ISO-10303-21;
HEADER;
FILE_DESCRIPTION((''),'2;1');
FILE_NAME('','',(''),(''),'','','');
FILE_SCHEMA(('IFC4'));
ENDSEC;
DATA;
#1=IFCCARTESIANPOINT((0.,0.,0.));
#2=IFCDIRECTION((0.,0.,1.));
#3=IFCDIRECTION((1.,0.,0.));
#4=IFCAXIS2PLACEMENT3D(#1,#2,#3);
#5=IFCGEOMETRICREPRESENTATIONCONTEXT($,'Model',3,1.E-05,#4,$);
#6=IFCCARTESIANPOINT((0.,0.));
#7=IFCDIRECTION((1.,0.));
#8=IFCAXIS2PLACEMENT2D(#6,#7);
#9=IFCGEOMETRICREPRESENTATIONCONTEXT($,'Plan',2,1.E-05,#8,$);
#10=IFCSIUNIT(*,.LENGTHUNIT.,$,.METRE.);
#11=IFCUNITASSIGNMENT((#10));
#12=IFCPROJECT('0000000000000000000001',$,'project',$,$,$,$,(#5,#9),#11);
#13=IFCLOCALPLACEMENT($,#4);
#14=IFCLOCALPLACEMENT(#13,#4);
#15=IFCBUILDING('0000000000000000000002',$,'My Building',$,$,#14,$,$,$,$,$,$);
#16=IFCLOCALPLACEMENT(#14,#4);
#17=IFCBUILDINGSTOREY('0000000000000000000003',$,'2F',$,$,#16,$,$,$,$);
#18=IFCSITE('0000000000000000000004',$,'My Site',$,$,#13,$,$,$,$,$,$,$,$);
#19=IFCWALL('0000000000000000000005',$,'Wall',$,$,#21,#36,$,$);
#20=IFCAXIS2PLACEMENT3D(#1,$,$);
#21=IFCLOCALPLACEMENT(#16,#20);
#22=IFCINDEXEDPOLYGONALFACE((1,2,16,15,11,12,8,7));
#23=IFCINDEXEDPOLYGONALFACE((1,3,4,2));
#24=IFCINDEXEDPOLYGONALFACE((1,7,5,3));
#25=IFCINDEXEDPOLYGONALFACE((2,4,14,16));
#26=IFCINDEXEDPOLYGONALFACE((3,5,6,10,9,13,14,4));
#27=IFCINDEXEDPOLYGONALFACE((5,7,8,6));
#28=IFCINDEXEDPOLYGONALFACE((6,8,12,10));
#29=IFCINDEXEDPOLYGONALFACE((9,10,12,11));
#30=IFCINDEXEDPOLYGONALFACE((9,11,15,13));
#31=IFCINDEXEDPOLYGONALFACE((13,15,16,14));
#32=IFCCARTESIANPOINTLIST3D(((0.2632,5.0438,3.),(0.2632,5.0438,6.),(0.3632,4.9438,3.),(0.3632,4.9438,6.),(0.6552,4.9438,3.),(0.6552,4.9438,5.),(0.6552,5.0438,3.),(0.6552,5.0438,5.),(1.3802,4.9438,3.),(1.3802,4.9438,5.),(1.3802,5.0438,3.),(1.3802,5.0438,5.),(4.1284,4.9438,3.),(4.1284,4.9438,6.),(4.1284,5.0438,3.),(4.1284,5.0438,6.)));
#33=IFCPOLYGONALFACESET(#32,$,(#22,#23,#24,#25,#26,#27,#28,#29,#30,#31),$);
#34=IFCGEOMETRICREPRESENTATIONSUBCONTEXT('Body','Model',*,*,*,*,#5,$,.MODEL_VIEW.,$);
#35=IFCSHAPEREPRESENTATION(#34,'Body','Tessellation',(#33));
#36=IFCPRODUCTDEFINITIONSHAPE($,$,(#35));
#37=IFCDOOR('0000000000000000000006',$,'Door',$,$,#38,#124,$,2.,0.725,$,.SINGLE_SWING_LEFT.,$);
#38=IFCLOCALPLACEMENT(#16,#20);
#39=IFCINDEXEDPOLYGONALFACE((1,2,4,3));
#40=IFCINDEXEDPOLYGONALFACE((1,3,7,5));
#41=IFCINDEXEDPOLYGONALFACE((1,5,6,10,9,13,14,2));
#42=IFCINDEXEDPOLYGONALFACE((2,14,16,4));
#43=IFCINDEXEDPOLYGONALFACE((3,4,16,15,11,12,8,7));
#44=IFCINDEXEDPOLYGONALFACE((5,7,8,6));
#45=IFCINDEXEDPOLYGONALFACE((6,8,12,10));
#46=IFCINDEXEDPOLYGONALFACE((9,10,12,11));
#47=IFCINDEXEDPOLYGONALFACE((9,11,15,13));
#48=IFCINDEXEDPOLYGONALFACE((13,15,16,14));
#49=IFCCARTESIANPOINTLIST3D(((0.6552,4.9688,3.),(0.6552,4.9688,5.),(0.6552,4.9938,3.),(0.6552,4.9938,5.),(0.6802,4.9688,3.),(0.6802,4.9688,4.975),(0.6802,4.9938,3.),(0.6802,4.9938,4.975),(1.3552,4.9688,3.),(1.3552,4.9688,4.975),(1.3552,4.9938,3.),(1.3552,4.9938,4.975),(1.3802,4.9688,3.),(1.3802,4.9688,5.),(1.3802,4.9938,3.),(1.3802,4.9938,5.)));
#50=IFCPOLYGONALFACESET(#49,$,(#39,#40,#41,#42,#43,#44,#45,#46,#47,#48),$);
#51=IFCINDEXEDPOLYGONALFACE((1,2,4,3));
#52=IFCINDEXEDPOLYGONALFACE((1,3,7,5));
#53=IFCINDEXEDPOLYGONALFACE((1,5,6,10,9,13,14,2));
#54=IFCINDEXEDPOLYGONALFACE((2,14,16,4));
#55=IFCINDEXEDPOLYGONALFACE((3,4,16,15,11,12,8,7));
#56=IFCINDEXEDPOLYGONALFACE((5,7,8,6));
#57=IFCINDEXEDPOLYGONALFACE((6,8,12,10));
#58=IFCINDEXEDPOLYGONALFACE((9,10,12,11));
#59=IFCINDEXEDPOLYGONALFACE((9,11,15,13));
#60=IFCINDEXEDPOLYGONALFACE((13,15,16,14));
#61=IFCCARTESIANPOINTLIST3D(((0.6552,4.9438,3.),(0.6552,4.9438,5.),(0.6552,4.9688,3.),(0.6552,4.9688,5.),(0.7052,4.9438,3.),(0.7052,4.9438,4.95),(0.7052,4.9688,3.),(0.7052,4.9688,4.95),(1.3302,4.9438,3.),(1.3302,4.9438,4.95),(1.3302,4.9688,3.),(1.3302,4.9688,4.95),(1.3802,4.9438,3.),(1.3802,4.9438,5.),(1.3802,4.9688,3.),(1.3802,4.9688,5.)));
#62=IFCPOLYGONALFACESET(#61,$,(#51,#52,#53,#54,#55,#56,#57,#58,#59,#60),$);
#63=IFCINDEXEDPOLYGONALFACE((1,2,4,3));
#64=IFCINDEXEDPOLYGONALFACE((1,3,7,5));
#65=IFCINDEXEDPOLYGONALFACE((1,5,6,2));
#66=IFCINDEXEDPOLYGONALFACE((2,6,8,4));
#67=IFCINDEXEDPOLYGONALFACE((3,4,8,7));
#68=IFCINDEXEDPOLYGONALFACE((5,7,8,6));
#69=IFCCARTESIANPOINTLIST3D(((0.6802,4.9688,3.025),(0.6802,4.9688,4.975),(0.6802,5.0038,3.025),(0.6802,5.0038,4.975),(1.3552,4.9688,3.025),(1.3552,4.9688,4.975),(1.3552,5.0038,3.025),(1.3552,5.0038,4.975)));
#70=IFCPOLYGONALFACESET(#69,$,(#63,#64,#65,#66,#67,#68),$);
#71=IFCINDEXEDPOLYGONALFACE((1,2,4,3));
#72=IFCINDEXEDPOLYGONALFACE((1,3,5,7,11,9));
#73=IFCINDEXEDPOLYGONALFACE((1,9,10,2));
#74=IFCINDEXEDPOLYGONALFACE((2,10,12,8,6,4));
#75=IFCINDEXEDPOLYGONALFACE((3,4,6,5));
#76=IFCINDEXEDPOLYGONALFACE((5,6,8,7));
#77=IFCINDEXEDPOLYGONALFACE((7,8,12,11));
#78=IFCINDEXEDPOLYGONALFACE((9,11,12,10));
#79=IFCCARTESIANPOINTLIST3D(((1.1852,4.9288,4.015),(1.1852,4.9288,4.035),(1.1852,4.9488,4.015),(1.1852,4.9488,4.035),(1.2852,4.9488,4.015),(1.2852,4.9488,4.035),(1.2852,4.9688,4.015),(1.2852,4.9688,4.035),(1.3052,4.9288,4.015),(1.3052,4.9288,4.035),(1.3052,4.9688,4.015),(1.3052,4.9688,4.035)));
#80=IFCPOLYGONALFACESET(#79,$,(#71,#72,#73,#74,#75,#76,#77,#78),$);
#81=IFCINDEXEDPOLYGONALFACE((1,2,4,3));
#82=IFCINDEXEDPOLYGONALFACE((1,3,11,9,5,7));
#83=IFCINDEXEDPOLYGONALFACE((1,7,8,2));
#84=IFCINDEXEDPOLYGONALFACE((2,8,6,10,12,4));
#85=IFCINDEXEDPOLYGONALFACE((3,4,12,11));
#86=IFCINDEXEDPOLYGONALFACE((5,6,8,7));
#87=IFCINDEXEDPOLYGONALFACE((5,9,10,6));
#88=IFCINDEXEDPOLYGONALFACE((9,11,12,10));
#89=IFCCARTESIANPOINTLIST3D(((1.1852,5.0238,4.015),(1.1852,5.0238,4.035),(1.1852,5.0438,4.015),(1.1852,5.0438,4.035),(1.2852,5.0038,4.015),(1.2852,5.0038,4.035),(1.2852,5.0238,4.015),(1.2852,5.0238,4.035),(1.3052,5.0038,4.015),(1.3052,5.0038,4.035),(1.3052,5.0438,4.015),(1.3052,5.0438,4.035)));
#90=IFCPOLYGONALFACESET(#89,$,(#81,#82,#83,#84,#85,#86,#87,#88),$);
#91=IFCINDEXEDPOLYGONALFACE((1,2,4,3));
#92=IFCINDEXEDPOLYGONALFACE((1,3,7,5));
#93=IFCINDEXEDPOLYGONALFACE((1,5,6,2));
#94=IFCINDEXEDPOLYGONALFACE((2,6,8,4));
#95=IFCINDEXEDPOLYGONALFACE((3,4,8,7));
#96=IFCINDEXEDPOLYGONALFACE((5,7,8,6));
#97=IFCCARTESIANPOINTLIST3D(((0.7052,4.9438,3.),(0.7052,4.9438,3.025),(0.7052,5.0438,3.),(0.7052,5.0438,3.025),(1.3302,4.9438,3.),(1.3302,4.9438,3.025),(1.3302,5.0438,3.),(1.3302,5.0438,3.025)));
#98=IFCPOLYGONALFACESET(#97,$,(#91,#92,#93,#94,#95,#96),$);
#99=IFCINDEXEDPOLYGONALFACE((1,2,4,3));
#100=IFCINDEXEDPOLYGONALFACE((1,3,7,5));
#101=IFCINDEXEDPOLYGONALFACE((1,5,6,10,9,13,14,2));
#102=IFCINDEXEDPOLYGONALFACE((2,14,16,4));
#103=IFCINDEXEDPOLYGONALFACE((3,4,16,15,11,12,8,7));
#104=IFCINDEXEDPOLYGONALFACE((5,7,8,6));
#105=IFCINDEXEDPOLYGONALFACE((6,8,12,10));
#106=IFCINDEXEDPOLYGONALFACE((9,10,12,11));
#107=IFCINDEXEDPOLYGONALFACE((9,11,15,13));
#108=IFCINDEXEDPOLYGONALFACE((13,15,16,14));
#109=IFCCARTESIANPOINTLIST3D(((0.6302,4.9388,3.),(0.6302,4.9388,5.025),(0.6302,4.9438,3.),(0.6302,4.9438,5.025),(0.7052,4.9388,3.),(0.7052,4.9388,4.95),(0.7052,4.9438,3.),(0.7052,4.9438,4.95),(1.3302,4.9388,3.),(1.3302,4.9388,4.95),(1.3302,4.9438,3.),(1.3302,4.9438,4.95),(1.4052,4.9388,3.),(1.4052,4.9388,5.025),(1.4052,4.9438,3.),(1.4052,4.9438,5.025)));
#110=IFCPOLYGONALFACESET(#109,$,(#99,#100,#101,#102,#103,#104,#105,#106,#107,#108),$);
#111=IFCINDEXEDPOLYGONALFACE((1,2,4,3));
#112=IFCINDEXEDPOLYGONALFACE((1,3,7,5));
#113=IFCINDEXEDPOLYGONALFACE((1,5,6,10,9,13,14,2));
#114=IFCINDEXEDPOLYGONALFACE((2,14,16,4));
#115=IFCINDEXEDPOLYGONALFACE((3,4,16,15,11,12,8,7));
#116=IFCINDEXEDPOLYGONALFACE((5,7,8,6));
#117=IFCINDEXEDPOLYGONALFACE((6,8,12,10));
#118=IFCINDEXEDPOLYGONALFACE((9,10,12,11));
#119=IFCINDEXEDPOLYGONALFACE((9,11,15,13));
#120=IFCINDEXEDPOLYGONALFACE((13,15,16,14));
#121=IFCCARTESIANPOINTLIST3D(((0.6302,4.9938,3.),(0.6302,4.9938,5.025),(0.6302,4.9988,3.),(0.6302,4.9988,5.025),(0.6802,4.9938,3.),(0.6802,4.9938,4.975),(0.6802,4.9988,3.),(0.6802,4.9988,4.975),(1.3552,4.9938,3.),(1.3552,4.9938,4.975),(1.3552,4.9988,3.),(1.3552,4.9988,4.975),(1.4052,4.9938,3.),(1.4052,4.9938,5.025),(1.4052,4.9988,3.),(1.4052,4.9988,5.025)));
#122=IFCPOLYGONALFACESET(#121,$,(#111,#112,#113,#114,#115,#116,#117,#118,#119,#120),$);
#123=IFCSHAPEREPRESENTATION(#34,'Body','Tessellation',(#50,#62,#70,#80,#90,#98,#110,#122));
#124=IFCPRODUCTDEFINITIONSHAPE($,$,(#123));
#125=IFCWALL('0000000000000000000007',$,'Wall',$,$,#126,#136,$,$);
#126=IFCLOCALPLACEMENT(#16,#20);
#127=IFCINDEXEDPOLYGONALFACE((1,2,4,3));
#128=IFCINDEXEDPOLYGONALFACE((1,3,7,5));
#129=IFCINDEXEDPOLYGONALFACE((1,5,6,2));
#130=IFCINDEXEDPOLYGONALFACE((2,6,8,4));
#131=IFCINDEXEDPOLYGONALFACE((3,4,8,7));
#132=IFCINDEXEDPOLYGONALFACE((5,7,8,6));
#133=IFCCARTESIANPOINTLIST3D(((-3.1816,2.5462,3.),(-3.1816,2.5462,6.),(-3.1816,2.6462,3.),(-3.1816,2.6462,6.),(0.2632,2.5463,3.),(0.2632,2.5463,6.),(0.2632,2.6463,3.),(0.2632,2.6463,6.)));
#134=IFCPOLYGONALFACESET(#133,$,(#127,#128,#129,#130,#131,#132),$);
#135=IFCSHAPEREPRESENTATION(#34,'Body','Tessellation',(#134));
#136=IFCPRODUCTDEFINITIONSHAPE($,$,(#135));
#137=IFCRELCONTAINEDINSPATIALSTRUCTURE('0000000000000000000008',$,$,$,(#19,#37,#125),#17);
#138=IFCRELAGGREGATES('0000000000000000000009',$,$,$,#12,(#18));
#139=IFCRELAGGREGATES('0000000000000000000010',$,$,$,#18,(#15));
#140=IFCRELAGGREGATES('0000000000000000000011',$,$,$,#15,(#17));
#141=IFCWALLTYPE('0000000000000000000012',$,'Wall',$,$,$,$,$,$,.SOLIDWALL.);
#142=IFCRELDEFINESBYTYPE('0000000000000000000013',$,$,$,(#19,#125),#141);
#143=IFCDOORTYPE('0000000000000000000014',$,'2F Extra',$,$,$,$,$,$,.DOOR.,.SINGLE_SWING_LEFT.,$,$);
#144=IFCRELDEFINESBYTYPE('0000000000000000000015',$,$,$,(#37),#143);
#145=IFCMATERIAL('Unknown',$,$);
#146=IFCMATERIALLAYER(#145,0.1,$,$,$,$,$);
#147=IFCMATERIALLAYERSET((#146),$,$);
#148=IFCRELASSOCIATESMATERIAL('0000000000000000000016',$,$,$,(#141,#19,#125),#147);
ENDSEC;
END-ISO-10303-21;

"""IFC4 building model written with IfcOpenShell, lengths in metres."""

from ifc_helpers import new_model, entity, si_unit, frame, origin_with_axes, origin_2d_with_axis, place, context, subcontext, project, spatial, line, indexed_curve, outline, extrude, shape, source, transform, mapped, material, layer, layer_set, layer_usage, type_object, type_shapes, element, fill, save


model = new_model("IFC4")

# Units and contexts
model_context = context("Model", 3, precision=1e-05, world=origin_with_axes())
plan_context = context("Plan", 2, precision=1e-05, world=origin_2d_with_axis())
body_context_1 = subcontext(model_context, "Body", "Model", "MODEL_VIEW")
body_context_2 = subcontext(plan_context, "Body", "Plan", "PLAN_VIEW")
ifc_project = project(units=[si_unit("LENGTHUNIT", "METRE")], contexts=[model_context, plan_context])

# Site, building, storey
site_placement = place(None, origin_with_axes())
site = spatial("IfcSite", under=ifc_project, at=site_placement, Name="My Site")
building_placement = place(site_placement, origin_with_axes())
building = spatial("IfcBuilding", under=site, at=building_placement, Name="My Building")
storey_placement = place(building_placement, origin_with_axes())
storey = spatial("IfcBuildingStorey", under=building, at=storey_placement, Name="2F")

# Shared definitions
ifc_material = material(Name="Unknown")
ifc_layer = layer(ifc_material, 0.1)
ifc_layer_set = layer_set([ifc_layer])
wall_type = type_object("IfcWallType", Name="Wall", PredefinedType="SOLIDWALL", material=ifc_layer_set)

# Wall, opening, door
ifc_layer_usage_1 = layer_usage(ifc_layer_set, "AXIS2", "POSITIVE", 0.0)
wall_1_placement = place(storey_placement, frame((4.1284, 5.0438, 3.0), z_axis=(0.0, 0.0, 1.0), x_axis=(-1.0, 0.0, 0.0)))
wall_1 = element("IfcWall", 1, at=wall_1_placement, inside=storey, type_object=wall_type, material=ifc_layer_usage_1, Name="Wall", context=body_context_1, shape_type="SweptSolid", body=[
    extrude(outline(indexed_curve([(0.0, 0.0), (0.0, 0.1), (3.7652, 0.1), (3.8652, 0.0)], segments=[line(1, 2, 3, 4, 1)])), origin_with_axes(), (0.0, 0.0, 1.0), 3.0),
])
shared_shape_1 = source(origin_with_axes(), body_context_1, "Body", "SweptSolid", [
    extrude(outline(indexed_curve([(0.0, 0.0), (0.725, 0.0), (0.725, 2.0), (0.0, 2.0)], segments=[line(1, 2, 3, 4, 1)])), frame((0.0, -0.6, 0.0), z_axis=(0.0, -1.0, 0.0), x_axis=(1.0, 0.0, 0.0)), (0.0, 0.0, -1.0), 1.2),
])
opening_1_placement = place(wall_1_placement, frame((3.4732, 0.1, 0.0), z_axis=(0.0, 0.0, 1.0), x_axis=(-1.0, 0.0, 0.0)))
opening_1 = element("IfcOpeningElement", 2, at=opening_1_placement, cuts=wall_1, PredefinedType="OPENING", context=body_context_1, shape_type="MappedRepresentation", body=[
    mapped(shared_shape_1, transform((0.0, 0.0, 0.0), x_axis=(1.0, 0.0, 0.0), y_axis=(0.0, 1.0, 0.0), z_axis=(0.0, 0.0, 1.0), scale=1.0)),
])
door_type_1 = type_object("IfcDoorType", Name="2F Extra", OperationType="SINGLE_SWING_LEFT", PredefinedType="DOOR")
shared_shape_2 = source(origin_with_axes(), body_context_1, "Body", "SweptSolid", [
    extrude(outline(indexed_curve([(0.0, 0.0), (0.0, 2.0), (0.725, 2.0), (0.725, 0.0), (0.7, 0.0), (0.7, 1.975), (0.025, 1.975), (0.025, 0.0)], segments=[line(1, 2, 3, 4, 5, 6, 7, 8, 1)])), frame((0.0, 0.025, 0.0), z_axis=(0.0, -1.0, 0.0), x_axis=(1.0, 0.0, 0.0)), (0.0, 0.0, -1.0), 0.025),
    extrude(outline(indexed_curve([(0.0, 0.0), (0.0, 2.0), (0.725, 2.0), (0.725, 0.0), (0.675, 0.0), (0.675, 1.95), (0.05, 1.95), (0.05, 0.0)], segments=[line(1, 2, 3, 4, 5, 6, 7, 8, 1)])), frame((0.0, 0.0, 0.0), z_axis=(0.0, -1.0, 0.0), x_axis=(1.0, 0.0, 0.0)), (0.0, 0.0, -1.0), 0.025),
    extrude(outline(indexed_curve([(0.0, 0.0), (0.675, 0.0), (0.675, 0.035), (0.0, 0.035)], segments=[line(1, 2, 3, 4, 1)])), frame((0.025, 0.025, 0.025), z_axis=(0.0, 0.0, 1.0), x_axis=(1.0, 0.0, 0.0)), (0.0, 0.0, 1.0), 1.95),
    extrude(outline(indexed_curve([(0.0, 0.0), (0.0, -0.04), (-0.12, -0.04), (-0.12, -0.02), (-0.02, -0.02), (-0.02, 0.0)], segments=[line(1, 2, 3, 4, 5, 6, 1)])), frame((0.65, 0.025, 1.015), z_axis=(0.0, 0.0, 1.0), x_axis=(1.0, 0.0, 0.0)), (0.0, 0.0, 1.0), 0.02),
    extrude(outline(indexed_curve([(0.0, 0.0), (0.0, 0.04), (-0.12, 0.04), (-0.12, 0.02), (-0.02, 0.02), (-0.02, 0.0)], segments=[line(1, 2, 3, 4, 5, 6, 1)])), frame((0.65, 0.06, 1.015), z_axis=(0.0, 0.0, 1.0), x_axis=(1.0, 0.0, 0.0)), (0.0, 0.0, 1.0), 0.02),
    extrude(outline(indexed_curve([(0.0, 0.0), (0.625, 0.0), (0.625, 0.1), (0.0, 0.1)], segments=[line(1, 2, 3, 4, 1)])), frame((0.05, 0.0, 0.0), z_axis=(0.0, 0.0, 1.0), x_axis=(1.0, 0.0, 0.0)), (0.0, 0.0, 1.0), 0.025),
    extrude(outline(indexed_curve([(0.0, 0.0), (0.0, 2.025), (0.775, 2.025), (0.775, 0.0), (0.7, 0.0), (0.7, 1.95), (0.075, 1.95), (0.075, 0.0)], segments=[line(1, 2, 3, 4, 5, 6, 7, 8, 1)])), frame((-0.025, -0.005, 0.0), z_axis=(0.0, -1.0, 0.0), x_axis=(1.0, 0.0, 0.0)), (0.0, 0.0, -1.0), 0.005),
    extrude(outline(indexed_curve([(0.0, 0.0), (0.0, 2.025), (0.775, 2.025), (0.775, 0.0), (0.725, 0.0), (0.725, 1.975), (0.05, 1.975), (0.05, 0.0)], segments=[line(1, 2, 3, 4, 5, 6, 7, 8, 1)])), frame((-0.025, 0.05, 0.0), z_axis=(0.0, -1.0, 0.0), x_axis=(1.0, 0.0, 0.0)), (0.0, 0.0, -1.0), 0.005),
])
shared_shape_3 = source(origin_with_axes(), body_context_2, "Body", "Curve2D", [
    entity("IfcIndexedPolyCurve", entity("IfcCartesianPointList2D", [[0.0, 0.0], [0.0, 0.05], [0.025, 0.05], [0.025, 0.025], [0.05, 0.025], [0.05, 0.0]]), [entity("IfcLineIndex", [1, 2, 3, 4, 5, 6, 1])]),
    entity("IfcIndexedPolyCurve", entity("IfcCartesianPointList2D", [[0.725, 0.0], [0.725, 0.05], [0.7, 0.05], [0.7, 0.025], [0.675, 0.025], [0.675, 0.0]]), [entity("IfcLineIndex", [1, 2, 3, 4, 5, 6, 1])]),
    entity("IfcTrimmedCurve", entity("IfcEllipse", entity("IfcAxis2Placement2D", entity("IfcCartesianPoint", [0.06, 0.05]), entity("IfcDirection", [1.0, 0.0])), 0.64, 0.675), [entity("IfcCartesianPoint", [0.7, 0.05])], [entity("IfcCartesianPoint", [0.06, 0.725])], True, "CARTESIAN"),
    entity("IfcIndexedPolyCurve", entity("IfcCartesianPointList2D", [[0.025, 0.05], [0.06, 0.05], [0.06, 0.725], [0.025, 0.725]]), [entity("IfcLineIndex", [1, 2, 3, 4, 1])]),
])
type_shapes(door_type_1, [shared_shape_2, shared_shape_3])
door_1_placement = place(opening_1_placement, frame((0.0, 0.0, 0.0), z_axis=(0.0, 0.0, 1.0), x_axis=(1.0, 0.0, 0.0)))
door_1 = element("IfcDoor", 3, at=door_1_placement, inside=storey, type_object=door_type_1, Name="Door", OperationType="SINGLE_SWING_LEFT", OverallHeight=2.0, OverallWidth=0.725, shapes=[
    shape(body_context_1, "Body", "MappedRepresentation", [mapped(shared_shape_2, transform((0.0, 0.0, 0.0), x_axis=(1.0, 0.0, 0.0), y_axis=(0.0, 1.0, 0.0), z_axis=(0.0, 0.0, 1.0), scale=1.0))]),
    shape(body_context_2, "Body", "MappedRepresentation", [mapped(shared_shape_3, transform((0.0, 0.0, 0.0), x_axis=(1.0, 0.0, 0.0), y_axis=(0.0, 1.0, 0.0), z_axis=(0.0, 0.0, 1.0), scale=1.0))]),
])
fill(opening_1, door_1)

# Wall
ifc_layer_usage_2 = layer_usage(ifc_layer_set, "AXIS2", "POSITIVE", 0.0)
wall_2_placement = place(storey_placement, frame((0.2632, 2.6463, 3.0), z_axis=(0.0, 0.0, 1.0), x_axis=(-1.0, 0.0, 0.0)))
element("IfcWall", 4, at=wall_2_placement, inside=storey, type_object=wall_type, material=ifc_layer_usage_2, Name="Wall", context=body_context_1, shape_type="SweptSolid", body=[
    extrude(outline(indexed_curve([(0.0, 0.0), (0.0, 0.1), (3.4448, 0.1), (3.4448, 0.0)], segments=[line(1, 2, 3, 4, 1)])), origin_with_axes(), (0.0, 0.0, 1.0), 3.0),
])

save(model, "model.ifc")
